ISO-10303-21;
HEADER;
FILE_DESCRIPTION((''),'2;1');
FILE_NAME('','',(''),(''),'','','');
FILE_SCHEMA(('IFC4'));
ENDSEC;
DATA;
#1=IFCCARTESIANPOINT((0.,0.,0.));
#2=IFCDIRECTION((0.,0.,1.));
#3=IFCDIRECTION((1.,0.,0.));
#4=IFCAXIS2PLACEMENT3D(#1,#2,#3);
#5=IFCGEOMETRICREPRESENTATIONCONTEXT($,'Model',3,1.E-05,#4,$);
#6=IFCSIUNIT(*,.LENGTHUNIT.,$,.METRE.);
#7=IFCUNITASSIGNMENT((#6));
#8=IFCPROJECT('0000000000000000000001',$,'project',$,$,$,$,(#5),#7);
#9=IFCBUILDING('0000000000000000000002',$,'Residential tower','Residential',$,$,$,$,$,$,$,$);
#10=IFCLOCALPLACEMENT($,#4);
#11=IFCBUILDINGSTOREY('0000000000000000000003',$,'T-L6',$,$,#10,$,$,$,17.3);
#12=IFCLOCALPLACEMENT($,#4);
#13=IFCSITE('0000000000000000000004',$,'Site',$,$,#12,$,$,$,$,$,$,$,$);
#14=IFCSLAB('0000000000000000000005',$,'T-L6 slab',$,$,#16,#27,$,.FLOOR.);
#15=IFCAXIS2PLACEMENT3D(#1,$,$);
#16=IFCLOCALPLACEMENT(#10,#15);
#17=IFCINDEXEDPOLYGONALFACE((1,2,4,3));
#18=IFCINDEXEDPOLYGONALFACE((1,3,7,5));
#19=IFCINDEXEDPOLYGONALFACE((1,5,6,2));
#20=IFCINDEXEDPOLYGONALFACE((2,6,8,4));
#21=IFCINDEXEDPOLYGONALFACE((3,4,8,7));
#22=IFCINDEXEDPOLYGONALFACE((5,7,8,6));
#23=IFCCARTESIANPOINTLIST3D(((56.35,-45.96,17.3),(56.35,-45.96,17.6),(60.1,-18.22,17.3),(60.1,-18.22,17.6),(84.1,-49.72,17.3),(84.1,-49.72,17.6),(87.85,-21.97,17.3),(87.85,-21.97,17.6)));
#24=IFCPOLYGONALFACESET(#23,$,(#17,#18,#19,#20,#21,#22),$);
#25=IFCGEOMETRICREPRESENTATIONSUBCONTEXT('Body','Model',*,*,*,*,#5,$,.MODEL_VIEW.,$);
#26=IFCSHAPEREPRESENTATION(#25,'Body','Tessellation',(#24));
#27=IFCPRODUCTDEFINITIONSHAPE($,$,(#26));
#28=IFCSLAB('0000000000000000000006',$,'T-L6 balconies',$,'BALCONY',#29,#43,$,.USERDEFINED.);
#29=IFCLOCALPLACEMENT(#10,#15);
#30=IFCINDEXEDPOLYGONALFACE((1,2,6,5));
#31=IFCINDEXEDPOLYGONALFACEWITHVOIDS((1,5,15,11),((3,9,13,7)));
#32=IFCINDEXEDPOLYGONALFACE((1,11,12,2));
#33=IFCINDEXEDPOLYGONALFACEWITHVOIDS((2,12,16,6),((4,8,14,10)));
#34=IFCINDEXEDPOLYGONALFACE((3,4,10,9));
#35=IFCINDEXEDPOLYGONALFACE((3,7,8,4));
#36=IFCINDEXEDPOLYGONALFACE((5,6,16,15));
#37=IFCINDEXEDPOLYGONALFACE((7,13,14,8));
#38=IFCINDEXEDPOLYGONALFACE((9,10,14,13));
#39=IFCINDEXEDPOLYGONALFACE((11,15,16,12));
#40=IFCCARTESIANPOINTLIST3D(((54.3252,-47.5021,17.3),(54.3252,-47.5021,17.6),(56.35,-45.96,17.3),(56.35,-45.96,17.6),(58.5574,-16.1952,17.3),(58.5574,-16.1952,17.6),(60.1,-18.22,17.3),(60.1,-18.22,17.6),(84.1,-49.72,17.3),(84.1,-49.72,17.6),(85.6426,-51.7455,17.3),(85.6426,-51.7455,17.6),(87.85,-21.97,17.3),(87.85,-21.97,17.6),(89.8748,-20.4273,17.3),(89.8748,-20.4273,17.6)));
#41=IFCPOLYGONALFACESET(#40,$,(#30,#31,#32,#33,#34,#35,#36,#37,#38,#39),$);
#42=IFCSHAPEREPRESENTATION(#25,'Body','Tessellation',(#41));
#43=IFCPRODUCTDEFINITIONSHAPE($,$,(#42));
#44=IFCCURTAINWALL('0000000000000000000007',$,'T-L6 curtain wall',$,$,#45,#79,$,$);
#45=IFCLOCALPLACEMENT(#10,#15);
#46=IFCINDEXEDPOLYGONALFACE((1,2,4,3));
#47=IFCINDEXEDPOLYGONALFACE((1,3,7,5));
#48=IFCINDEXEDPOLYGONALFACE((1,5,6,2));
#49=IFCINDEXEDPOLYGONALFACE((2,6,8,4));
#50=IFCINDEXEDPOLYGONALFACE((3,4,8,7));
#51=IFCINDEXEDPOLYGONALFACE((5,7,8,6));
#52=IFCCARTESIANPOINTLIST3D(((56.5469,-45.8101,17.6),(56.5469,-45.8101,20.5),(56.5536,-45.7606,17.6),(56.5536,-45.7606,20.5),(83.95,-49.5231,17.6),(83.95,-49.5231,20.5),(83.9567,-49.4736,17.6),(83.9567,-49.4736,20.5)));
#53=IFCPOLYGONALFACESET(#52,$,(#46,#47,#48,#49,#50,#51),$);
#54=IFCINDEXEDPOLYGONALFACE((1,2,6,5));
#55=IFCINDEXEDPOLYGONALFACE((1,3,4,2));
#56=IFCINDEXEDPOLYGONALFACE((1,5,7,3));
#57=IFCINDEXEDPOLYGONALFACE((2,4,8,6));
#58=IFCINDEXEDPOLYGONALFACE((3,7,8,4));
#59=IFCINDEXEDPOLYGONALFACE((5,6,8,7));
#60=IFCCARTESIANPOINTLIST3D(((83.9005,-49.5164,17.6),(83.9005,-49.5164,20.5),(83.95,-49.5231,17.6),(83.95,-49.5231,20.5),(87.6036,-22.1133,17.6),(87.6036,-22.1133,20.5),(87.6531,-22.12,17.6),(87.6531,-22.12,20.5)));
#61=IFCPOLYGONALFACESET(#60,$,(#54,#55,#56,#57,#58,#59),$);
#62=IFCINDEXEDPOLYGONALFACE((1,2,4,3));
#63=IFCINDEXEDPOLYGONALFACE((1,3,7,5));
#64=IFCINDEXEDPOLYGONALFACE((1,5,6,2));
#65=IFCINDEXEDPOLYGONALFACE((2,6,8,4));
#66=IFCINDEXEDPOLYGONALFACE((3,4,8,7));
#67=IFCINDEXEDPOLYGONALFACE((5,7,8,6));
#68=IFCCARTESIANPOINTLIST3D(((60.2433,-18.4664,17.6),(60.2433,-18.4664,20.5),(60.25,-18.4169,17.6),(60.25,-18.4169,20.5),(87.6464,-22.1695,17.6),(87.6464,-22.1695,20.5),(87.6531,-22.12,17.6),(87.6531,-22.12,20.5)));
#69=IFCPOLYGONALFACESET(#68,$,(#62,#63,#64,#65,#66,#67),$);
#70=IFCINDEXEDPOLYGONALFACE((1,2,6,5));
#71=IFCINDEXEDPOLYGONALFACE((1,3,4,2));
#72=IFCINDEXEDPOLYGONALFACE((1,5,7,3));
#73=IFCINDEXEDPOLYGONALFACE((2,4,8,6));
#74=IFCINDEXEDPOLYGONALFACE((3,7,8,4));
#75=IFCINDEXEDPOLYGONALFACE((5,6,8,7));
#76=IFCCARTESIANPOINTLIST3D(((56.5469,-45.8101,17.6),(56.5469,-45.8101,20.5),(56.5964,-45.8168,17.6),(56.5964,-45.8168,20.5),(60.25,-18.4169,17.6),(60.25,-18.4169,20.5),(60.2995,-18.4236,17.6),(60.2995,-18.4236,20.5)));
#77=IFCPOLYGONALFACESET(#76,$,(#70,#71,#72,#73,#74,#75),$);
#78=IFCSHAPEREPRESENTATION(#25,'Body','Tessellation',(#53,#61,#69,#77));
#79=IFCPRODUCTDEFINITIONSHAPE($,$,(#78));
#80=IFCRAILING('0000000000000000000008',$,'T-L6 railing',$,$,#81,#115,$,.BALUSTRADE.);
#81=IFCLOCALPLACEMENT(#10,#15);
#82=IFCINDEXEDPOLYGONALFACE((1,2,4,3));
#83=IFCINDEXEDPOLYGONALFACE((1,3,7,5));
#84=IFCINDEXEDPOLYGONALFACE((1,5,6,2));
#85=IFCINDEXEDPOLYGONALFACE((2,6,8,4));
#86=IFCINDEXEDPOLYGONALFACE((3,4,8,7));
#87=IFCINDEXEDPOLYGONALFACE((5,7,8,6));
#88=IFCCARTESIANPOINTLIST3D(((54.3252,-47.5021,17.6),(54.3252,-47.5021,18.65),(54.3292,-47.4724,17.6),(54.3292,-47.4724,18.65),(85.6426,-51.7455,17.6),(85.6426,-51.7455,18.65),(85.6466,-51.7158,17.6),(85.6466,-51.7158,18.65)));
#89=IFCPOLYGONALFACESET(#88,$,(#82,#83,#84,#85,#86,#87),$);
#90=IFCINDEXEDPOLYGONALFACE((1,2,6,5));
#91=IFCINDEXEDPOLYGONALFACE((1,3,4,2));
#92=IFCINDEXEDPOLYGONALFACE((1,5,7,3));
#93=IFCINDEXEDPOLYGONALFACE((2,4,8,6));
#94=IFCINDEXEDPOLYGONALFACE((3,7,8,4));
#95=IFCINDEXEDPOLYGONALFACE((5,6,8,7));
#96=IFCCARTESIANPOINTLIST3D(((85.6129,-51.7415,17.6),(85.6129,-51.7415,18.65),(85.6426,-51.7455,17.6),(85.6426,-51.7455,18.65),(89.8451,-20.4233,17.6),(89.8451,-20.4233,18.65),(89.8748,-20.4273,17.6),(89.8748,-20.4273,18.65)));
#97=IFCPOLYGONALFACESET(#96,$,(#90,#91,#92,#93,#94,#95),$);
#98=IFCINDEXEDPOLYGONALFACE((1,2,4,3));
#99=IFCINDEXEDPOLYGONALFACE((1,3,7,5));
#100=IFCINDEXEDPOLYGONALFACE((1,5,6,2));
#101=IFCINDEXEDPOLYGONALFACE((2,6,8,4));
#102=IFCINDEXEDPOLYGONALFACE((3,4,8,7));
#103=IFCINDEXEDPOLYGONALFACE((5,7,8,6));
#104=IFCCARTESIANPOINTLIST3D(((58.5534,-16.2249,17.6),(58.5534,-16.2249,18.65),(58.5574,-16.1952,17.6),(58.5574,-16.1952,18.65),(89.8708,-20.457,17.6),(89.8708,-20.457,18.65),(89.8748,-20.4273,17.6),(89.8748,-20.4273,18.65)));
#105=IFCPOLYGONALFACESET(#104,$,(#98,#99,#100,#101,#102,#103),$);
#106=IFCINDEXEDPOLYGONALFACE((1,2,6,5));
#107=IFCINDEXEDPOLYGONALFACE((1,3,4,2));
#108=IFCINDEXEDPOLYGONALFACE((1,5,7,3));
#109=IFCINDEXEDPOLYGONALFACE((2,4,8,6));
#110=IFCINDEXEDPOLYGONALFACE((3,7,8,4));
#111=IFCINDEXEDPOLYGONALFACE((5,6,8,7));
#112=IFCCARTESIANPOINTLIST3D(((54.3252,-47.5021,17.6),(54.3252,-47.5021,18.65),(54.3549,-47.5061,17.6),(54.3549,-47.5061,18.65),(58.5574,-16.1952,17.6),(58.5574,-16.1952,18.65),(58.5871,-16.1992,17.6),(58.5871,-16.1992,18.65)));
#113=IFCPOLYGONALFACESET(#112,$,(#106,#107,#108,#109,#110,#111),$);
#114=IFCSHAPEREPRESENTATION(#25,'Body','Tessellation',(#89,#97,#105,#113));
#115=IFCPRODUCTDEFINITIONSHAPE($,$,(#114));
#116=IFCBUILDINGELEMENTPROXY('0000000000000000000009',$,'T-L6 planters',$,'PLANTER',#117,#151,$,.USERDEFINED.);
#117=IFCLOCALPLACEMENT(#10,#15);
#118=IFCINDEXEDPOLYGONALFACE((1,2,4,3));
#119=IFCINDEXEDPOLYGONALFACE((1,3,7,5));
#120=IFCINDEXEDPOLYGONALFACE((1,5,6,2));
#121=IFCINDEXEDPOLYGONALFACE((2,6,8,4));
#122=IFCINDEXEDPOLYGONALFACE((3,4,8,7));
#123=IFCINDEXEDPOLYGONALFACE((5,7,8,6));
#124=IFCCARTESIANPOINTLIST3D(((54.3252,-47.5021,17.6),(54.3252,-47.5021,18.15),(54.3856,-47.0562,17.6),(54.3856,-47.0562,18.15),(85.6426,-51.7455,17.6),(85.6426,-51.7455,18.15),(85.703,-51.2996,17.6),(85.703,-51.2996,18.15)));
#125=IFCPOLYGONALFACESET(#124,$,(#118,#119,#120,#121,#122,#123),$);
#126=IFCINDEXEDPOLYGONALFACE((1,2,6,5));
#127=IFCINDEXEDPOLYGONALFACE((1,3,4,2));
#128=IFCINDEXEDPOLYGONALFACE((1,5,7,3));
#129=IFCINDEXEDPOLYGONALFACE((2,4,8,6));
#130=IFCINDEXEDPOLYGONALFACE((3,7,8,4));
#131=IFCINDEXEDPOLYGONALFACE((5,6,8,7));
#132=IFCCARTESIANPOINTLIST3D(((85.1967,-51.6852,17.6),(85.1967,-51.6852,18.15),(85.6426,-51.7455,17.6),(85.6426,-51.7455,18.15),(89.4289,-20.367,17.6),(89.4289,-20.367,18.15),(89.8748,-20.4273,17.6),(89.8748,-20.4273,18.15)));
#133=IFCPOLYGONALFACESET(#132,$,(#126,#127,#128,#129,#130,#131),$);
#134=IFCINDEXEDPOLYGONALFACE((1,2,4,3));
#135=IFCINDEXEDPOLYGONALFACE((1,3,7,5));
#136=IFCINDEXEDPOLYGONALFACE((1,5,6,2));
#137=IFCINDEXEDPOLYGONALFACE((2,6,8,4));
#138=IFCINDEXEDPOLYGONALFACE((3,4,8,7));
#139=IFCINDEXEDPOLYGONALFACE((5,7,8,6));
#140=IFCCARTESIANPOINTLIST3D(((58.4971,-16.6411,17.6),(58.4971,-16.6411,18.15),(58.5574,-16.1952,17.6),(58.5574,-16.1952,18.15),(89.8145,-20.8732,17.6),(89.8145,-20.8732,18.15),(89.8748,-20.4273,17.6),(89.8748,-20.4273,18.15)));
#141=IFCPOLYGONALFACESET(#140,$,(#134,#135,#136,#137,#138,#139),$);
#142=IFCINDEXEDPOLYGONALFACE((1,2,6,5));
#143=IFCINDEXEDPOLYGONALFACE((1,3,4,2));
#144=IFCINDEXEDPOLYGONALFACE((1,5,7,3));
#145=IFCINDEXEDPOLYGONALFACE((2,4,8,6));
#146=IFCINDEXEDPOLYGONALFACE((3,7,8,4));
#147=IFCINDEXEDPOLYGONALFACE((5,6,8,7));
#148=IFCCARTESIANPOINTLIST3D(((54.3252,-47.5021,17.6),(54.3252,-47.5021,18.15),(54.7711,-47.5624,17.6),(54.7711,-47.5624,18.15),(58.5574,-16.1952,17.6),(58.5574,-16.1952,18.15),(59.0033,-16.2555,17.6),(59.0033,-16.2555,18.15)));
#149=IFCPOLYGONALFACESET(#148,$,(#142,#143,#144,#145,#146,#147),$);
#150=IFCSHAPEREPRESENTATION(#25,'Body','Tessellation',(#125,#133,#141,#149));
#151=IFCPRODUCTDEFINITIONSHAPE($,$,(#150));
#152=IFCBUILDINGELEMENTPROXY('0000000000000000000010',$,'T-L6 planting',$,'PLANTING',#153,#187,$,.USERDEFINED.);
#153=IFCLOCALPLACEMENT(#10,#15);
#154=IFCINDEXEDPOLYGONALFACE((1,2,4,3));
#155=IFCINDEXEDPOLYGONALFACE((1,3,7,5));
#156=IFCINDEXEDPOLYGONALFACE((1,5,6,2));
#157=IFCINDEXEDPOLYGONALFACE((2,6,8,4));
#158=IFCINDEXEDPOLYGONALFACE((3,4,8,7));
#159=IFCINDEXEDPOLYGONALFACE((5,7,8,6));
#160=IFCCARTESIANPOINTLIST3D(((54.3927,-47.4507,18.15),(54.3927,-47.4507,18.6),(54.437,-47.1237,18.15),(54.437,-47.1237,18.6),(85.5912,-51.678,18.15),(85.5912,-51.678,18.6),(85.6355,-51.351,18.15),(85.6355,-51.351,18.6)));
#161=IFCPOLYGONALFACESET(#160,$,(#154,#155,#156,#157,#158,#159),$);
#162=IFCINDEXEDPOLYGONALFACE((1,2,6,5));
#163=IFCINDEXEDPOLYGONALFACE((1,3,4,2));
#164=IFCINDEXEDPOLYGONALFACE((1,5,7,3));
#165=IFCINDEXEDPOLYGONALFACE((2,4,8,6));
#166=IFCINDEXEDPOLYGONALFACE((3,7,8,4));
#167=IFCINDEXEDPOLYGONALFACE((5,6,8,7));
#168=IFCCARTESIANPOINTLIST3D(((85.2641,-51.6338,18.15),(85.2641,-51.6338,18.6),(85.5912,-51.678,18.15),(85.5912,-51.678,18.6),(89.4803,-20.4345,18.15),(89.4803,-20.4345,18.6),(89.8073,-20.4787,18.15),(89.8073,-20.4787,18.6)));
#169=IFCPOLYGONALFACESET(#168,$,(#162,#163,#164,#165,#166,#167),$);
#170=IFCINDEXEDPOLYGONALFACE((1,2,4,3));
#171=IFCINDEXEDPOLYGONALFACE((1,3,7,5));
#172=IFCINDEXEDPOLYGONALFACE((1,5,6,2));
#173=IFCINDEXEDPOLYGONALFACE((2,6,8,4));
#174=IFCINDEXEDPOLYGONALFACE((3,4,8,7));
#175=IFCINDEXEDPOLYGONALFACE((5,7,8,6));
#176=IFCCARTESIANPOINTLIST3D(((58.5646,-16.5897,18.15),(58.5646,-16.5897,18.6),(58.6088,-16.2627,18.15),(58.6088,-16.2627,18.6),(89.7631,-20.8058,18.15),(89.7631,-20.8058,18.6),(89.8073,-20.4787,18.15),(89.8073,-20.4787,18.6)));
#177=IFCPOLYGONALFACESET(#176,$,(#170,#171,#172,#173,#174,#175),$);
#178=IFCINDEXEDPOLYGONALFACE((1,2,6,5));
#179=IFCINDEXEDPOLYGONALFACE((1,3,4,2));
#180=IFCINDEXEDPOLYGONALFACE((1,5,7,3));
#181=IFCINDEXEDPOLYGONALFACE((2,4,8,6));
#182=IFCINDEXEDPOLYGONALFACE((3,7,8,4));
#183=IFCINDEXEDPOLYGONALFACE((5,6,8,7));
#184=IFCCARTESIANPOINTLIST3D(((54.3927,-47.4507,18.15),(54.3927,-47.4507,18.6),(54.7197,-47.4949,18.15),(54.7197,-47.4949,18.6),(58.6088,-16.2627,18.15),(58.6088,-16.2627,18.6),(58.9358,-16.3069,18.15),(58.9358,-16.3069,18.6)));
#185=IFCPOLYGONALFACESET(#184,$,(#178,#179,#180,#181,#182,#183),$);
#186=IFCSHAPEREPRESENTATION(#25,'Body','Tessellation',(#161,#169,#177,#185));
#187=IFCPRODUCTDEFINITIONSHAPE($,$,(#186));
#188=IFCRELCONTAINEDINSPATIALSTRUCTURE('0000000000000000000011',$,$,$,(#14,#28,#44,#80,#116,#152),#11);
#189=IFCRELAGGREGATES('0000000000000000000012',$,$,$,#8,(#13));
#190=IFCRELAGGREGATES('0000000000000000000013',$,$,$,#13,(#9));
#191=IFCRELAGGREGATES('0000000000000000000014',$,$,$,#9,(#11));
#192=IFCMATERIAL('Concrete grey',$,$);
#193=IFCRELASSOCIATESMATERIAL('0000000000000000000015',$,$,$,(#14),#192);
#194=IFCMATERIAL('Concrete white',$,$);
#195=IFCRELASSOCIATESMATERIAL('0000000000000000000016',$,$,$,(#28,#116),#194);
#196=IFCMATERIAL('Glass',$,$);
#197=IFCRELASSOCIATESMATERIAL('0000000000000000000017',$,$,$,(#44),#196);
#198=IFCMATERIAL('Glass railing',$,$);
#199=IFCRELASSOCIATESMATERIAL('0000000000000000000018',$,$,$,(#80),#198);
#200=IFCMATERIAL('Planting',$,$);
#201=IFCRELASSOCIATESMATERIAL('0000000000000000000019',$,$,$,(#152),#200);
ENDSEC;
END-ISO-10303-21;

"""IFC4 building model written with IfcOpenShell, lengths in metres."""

from ifc_helpers import new_model, si_unit, frame, origin_with_axes, place, context, subcontext, project, spatial, polyline, outline, extrude, material, element, save


model = new_model("IFC4")

# Units and contexts
model_context = context("Model", 3, precision=1e-05, world=origin_with_axes())
body_context = subcontext(model_context, "Body", "Model", "MODEL_VIEW")
ifc_project = project(units=[si_unit("LENGTHUNIT", "METRE")], contexts=[model_context])

# Site, building, storey
site_placement = place(None, origin_with_axes())
site = spatial("IfcSite", under=ifc_project, at=site_placement, Name="Site")
building = spatial("IfcBuilding", under=site, Name="Residential tower", Description="Residential")
storey_placement = place(None, origin_with_axes())
storey = spatial("IfcBuildingStorey", under=building, at=storey_placement, Name="T-L6", Elevation=17.3)

# Slabs
ifc_material_1 = material(Name="Concrete grey")
slab_1_placement = place(storey_placement, origin_with_axes())
element("IfcSlab", 1, at=slab_1_placement, inside=storey, material=ifc_material_1, Name="T-L6 slab", PredefinedType="FLOOR", context=body_context, shape_type="SweptSolid", body=[
    extrude(outline(polyline([(56.35, -45.96), (84.1, -49.72), (87.85, -21.97), (60.1, -18.22), (56.35, -45.96)])), frame((0.0, 0.0, 17.3), z_axis=(0.0, 0.0, 1.0), x_axis=(1.0, 0.0, 0.0)), (0.0, 0.0, 1.0), 0.3),
])
ifc_material_2 = material(Name="Concrete white")
slab_2_placement = place(storey_placement, origin_with_axes())
element("IfcSlab", 2, at=slab_2_placement, inside=storey, material=ifc_material_2, Name="T-L6 balconies", ObjectType="BALCONY", PredefinedType="USERDEFINED", context=body_context, shape_type="SweptSolid", body=[
    extrude(outline(polyline([(54.3252, -47.5021), (85.6426, -51.7455), (89.8748, -20.4273), (58.5574, -16.1952), (54.3252, -47.5021)]), holes=[polyline([(56.35, -45.96), (84.1, -49.72), (87.85, -21.97), (60.1, -18.22), (56.35, -45.96)])]), frame((0.0, 0.0, 17.3), z_axis=(0.0, 0.0, 1.0), x_axis=(1.0, 0.0, 0.0)), (0.0, 0.0, 1.0), 0.3),
])

# Curtain wall
ifc_material_3 = material(Name="Glass")
curtain_wall_placement = place(storey_placement, origin_with_axes())
element("IfcCurtainWall", 3, at=curtain_wall_placement, inside=storey, material=ifc_material_3, Name="T-L6 curtain wall", context=body_context, shape_type="SweptSolid", body=[
    extrude(outline(polyline([(56.5469, -45.8101), (83.95, -49.5231), (83.9567, -49.4736), (56.5536, -45.7606), (56.5469, -45.8101)])), frame((0.0, 0.0, 17.6), z_axis=(0.0, 0.0, 1.0), x_axis=(1.0, 0.0, 0.0)), (0.0, 0.0, 1.0), 2.9),
    extrude(outline(polyline([(83.95, -49.5231), (87.6531, -22.12), (87.6036, -22.1133), (83.9005, -49.5164), (83.95, -49.5231)])), frame((0.0, 0.0, 17.6), z_axis=(0.0, 0.0, 1.0), x_axis=(1.0, 0.0, 0.0)), (0.0, 0.0, 1.0), 2.9),
    extrude(outline(polyline([(87.6531, -22.12), (60.25, -18.4169), (60.2433, -18.4664), (87.6464, -22.1695), (87.6531, -22.12)])), frame((0.0, 0.0, 17.6), z_axis=(0.0, 0.0, 1.0), x_axis=(1.0, 0.0, 0.0)), (0.0, 0.0, 1.0), 2.9),
    extrude(outline(polyline([(60.25, -18.4169), (56.5469, -45.8101), (56.5964, -45.8168), (60.2995, -18.4236), (60.25, -18.4169)])), frame((0.0, 0.0, 17.6), z_axis=(0.0, 0.0, 1.0), x_axis=(1.0, 0.0, 0.0)), (0.0, 0.0, 1.0), 2.9),
])

# Railing
ifc_material_4 = material(Name="Glass railing")
railing_placement = place(storey_placement, origin_with_axes())
element("IfcRailing", 4, at=railing_placement, inside=storey, material=ifc_material_4, Name="T-L6 railing", PredefinedType="BALUSTRADE", context=body_context, shape_type="SweptSolid", body=[
    extrude(outline(polyline([(54.3252, -47.5021), (85.6426, -51.7455), (85.6466, -51.7158), (54.3292, -47.4724), (54.3252, -47.5021)])), frame((0.0, 0.0, 17.6), z_axis=(0.0, 0.0, 1.0), x_axis=(1.0, 0.0, 0.0)), (0.0, 0.0, 1.0), 1.05),
    extrude(outline(polyline([(85.6426, -51.7455), (89.8748, -20.4273), (89.8451, -20.4233), (85.6129, -51.7415), (85.6426, -51.7455)])), frame((0.0, 0.0, 17.6), z_axis=(0.0, 0.0, 1.0), x_axis=(1.0, 0.0, 0.0)), (0.0, 0.0, 1.0), 1.05),
    extrude(outline(polyline([(89.8748, -20.4273), (58.5574, -16.1952), (58.5534, -16.2249), (89.8708, -20.457), (89.8748, -20.4273)])), frame((0.0, 0.0, 17.6), z_axis=(0.0, 0.0, 1.0), x_axis=(1.0, 0.0, 0.0)), (0.0, 0.0, 1.0), 1.05),
    extrude(outline(polyline([(58.5574, -16.1952), (54.3252, -47.5021), (54.3549, -47.5061), (58.5871, -16.1992), (58.5574, -16.1952)])), frame((0.0, 0.0, 17.6), z_axis=(0.0, 0.0, 1.0), x_axis=(1.0, 0.0, 0.0)), (0.0, 0.0, 1.0), 1.05),
])

# Building element proxies
proxy_1_placement = place(storey_placement, origin_with_axes())
element("IfcBuildingElementProxy", 5, at=proxy_1_placement, inside=storey, material=ifc_material_2, Name="T-L6 planters", ObjectType="PLANTER", PredefinedType="USERDEFINED", context=body_context, shape_type="SweptSolid", body=[
    extrude(outline(polyline([(54.3252, -47.5021), (85.6426, -51.7455), (85.703, -51.2996), (54.3856, -47.0562), (54.3252, -47.5021)])), frame((0.0, 0.0, 17.6), z_axis=(0.0, 0.0, 1.0), x_axis=(1.0, 0.0, 0.0)), (0.0, 0.0, 1.0), 0.55),
    extrude(outline(polyline([(85.6426, -51.7455), (89.8748, -20.4273), (89.4289, -20.367), (85.1967, -51.6852), (85.6426, -51.7455)])), frame((0.0, 0.0, 17.6), z_axis=(0.0, 0.0, 1.0), x_axis=(1.0, 0.0, 0.0)), (0.0, 0.0, 1.0), 0.55),
    extrude(outline(polyline([(89.8748, -20.4273), (58.5574, -16.1952), (58.4971, -16.6411), (89.8145, -20.8732), (89.8748, -20.4273)])), frame((0.0, 0.0, 17.6), z_axis=(0.0, 0.0, 1.0), x_axis=(1.0, 0.0, 0.0)), (0.0, 0.0, 1.0), 0.55),
    extrude(outline(polyline([(58.5574, -16.1952), (54.3252, -47.5021), (54.7711, -47.5624), (59.0033, -16.2555), (58.5574, -16.1952)])), frame((0.0, 0.0, 17.6), z_axis=(0.0, 0.0, 1.0), x_axis=(1.0, 0.0, 0.0)), (0.0, 0.0, 1.0), 0.55),
])
ifc_material_5 = material(Name="Planting")
proxy_2_placement = place(storey_placement, origin_with_axes())
element("IfcBuildingElementProxy", 6, at=proxy_2_placement, inside=storey, material=ifc_material_5, Name="T-L6 planting", ObjectType="PLANTING", PredefinedType="USERDEFINED", context=body_context, shape_type="SweptSolid", body=[
    extrude(outline(polyline([(54.3927, -47.4507), (85.5912, -51.678), (85.6355, -51.351), (54.437, -47.1237), (54.3927, -47.4507)])), frame((0.0, 0.0, 18.15), z_axis=(0.0, 0.0, 1.0), x_axis=(1.0, 0.0, 0.0)), (0.0, 0.0, 1.0), 0.45),
    extrude(outline(polyline([(85.5912, -51.678), (89.8073, -20.4787), (89.4803, -20.4345), (85.2641, -51.6338), (85.5912, -51.678)])), frame((0.0, 0.0, 18.15), z_axis=(0.0, 0.0, 1.0), x_axis=(1.0, 0.0, 0.0)), (0.0, 0.0, 1.0), 0.45),
    extrude(outline(polyline([(89.8073, -20.4787), (58.6088, -16.2627), (58.5646, -16.5897), (89.7631, -20.8058), (89.8073, -20.4787)])), frame((0.0, 0.0, 18.15), z_axis=(0.0, 0.0, 1.0), x_axis=(1.0, 0.0, 0.0)), (0.0, 0.0, 1.0), 0.45),
    extrude(outline(polyline([(58.6088, -16.2627), (54.3927, -47.4507), (54.7197, -47.4949), (58.9358, -16.3069), (58.6088, -16.2627)])), frame((0.0, 0.0, 18.15), z_axis=(0.0, 0.0, 1.0), x_axis=(1.0, 0.0, 0.0)), (0.0, 0.0, 1.0), 0.45),
])

save(model, "model.ifc")
